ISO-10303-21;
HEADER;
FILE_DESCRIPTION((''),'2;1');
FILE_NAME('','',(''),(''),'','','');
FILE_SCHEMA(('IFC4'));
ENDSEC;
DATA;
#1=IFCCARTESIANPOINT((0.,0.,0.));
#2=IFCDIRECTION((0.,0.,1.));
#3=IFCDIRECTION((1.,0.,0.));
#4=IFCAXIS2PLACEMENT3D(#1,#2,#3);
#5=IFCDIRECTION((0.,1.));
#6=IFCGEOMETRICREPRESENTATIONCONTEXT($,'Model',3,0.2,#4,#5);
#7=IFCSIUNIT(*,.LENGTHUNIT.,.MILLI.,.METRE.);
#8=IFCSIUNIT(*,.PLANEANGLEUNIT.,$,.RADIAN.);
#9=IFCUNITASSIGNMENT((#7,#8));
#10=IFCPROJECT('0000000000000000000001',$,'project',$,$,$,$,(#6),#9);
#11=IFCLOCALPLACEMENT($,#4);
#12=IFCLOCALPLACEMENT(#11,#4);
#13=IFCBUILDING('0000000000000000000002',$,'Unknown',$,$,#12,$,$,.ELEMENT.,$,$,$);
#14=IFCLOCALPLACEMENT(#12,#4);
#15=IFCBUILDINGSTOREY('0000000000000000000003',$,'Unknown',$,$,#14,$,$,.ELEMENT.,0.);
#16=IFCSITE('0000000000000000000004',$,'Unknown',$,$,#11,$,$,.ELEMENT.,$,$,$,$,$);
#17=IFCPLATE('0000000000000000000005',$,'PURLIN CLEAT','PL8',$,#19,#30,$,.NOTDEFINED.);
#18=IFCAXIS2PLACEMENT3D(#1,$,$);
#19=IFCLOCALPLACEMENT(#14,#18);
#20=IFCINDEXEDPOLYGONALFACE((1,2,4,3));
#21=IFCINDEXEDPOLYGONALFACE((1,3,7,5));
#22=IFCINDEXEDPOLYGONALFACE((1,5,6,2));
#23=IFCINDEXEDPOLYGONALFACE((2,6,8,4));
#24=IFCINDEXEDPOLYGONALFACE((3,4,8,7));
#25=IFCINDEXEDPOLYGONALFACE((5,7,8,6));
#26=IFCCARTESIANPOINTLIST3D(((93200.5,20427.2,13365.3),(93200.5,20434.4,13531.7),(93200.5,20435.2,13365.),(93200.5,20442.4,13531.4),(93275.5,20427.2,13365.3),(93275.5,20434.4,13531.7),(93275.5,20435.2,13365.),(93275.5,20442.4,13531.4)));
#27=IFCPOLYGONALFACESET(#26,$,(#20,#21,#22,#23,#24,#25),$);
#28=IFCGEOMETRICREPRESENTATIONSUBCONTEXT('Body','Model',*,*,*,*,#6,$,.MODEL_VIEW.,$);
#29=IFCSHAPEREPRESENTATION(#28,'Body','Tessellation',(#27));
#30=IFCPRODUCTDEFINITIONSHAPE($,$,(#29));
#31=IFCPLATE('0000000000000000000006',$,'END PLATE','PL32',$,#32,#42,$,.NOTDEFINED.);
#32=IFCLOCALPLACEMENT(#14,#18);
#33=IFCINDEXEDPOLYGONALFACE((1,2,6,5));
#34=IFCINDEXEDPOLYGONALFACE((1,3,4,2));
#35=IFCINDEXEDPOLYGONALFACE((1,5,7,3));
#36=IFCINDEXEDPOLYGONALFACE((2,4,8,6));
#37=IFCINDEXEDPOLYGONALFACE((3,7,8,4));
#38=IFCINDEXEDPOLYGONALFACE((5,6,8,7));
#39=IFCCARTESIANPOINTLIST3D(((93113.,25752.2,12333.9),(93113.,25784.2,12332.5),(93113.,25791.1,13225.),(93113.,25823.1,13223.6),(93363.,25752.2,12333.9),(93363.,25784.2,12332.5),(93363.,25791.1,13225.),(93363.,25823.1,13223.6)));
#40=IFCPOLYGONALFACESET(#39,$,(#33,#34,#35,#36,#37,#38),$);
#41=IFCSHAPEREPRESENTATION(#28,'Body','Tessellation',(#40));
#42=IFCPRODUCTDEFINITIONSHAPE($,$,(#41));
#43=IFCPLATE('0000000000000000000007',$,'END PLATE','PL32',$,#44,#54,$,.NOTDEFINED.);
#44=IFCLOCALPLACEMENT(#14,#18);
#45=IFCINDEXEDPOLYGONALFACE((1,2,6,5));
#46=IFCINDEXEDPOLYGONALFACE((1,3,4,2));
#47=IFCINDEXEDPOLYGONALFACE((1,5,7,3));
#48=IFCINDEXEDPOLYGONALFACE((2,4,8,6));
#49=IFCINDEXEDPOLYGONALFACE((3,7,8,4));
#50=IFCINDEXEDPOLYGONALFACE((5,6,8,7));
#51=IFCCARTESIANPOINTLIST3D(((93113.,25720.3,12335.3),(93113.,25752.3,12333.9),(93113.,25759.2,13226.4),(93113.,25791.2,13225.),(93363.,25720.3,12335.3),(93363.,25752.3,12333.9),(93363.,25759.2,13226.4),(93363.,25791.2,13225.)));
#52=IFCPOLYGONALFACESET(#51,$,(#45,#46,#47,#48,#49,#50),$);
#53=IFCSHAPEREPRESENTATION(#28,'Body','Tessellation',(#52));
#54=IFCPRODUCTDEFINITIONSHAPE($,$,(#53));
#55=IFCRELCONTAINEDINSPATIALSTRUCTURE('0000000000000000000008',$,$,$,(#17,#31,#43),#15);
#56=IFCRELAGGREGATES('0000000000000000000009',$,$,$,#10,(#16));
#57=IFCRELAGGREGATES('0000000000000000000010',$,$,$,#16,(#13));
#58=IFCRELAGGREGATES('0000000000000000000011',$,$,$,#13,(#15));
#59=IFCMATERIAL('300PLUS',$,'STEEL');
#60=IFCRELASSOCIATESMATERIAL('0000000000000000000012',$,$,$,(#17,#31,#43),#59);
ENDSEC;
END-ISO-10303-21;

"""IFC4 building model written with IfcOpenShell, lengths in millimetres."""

from ifc_helpers import new_model, si_unit, direction, frame, origin_with_axes, place, context, subcontext, project, spatial, line, indexed_curve, outline, extrude, material, element, save


model = new_model("IFC4")

# Units and contexts
model_context = context("Model", 3, precision=0.2, world=origin_with_axes(), true_north=direction((0.0, 1.0)))
body_context = subcontext(model_context, "Body", "Model", "MODEL_VIEW")
ifc_project = project(units=[si_unit("LENGTHUNIT", "METRE", prefix="MILLI"), si_unit("PLANEANGLEUNIT", "RADIAN")], contexts=[model_context])

# Site, building, storey
site_placement = place(None, origin_with_axes())
site = spatial("IfcSite", under=ifc_project, at=site_placement, Name="Unknown", CompositionType="ELEMENT")
building_placement = place(site_placement, origin_with_axes())
building = spatial("IfcBuilding", under=site, at=building_placement, Name="Unknown", CompositionType="ELEMENT")
storey_placement = place(building_placement, origin_with_axes())
storey = spatial("IfcBuildingStorey", under=building, at=storey_placement, Name="Unknown", CompositionType="ELEMENT", Elevation=0.0)

# Plates
ifc_material_1 = material(Name="300PLUS", Category="STEEL")
plate_placement = place(storey_placement, frame((93200.5, 20431.2, 13365.2), z_axis=(0.0, -0.999065, 0.043229), x_axis=(1.0, 0.0, 0.0)))
element("IfcPlate", 1, at=plate_placement, inside=storey, material=ifc_material_1, Name="PURLIN CLEAT", Description="PL8", PredefinedType="NOTDEFINED", context=body_context, shape_type="SolidModel", body=[
    extrude(outline(indexed_curve([(0.0, 0.0), (75.0, 0.0), (75.0, 166.6), (0.0, 166.6)], segments=[line(1, 2, 3, 4, 1)])), frame((0.0, 0.0, 4.0), z_axis=(0.0, 0.0, 1.0), x_axis=(1.0, 0.0, 0.0)), (0.0, 0.0, -1.0), 8.0),
])
for number, where, z_axis, x_axis, name in (
    (2, (93363.0, 25807.1, 13224.3), (0.0, -0.999049, 0.043612), (-1.0, 0.0, 0.0), "END PLATE"),
    (3, (93363.0, 25775.2, 13225.7), (0.0, -0.999049, 0.043612), (-1.0, 0.0, 0.0), "END PLATE"),
):
    element("IfcPlate", number, at=place(storey_placement, frame(where, z_axis=z_axis, x_axis=x_axis)), inside=storey, material=ifc_material_1, Name=name, Description="PL32", PredefinedType="NOTDEFINED", context=body_context, shape_type="SolidModel", body=[
        extrude(outline(indexed_curve([(0.0, 0.0), (250.0, 0.0), (250.0, 891.9), (0.0, 891.9)], segments=[line(1, 2, 3, 4, 1)])), frame((0.0, 0.0, 16.0), z_axis=(0.0, 0.0, 1.0), x_axis=(1.0, 0.0, 0.0)), (0.0, 0.0, -1.0), 32.0),
    ])

save(model, "model.ifc")
